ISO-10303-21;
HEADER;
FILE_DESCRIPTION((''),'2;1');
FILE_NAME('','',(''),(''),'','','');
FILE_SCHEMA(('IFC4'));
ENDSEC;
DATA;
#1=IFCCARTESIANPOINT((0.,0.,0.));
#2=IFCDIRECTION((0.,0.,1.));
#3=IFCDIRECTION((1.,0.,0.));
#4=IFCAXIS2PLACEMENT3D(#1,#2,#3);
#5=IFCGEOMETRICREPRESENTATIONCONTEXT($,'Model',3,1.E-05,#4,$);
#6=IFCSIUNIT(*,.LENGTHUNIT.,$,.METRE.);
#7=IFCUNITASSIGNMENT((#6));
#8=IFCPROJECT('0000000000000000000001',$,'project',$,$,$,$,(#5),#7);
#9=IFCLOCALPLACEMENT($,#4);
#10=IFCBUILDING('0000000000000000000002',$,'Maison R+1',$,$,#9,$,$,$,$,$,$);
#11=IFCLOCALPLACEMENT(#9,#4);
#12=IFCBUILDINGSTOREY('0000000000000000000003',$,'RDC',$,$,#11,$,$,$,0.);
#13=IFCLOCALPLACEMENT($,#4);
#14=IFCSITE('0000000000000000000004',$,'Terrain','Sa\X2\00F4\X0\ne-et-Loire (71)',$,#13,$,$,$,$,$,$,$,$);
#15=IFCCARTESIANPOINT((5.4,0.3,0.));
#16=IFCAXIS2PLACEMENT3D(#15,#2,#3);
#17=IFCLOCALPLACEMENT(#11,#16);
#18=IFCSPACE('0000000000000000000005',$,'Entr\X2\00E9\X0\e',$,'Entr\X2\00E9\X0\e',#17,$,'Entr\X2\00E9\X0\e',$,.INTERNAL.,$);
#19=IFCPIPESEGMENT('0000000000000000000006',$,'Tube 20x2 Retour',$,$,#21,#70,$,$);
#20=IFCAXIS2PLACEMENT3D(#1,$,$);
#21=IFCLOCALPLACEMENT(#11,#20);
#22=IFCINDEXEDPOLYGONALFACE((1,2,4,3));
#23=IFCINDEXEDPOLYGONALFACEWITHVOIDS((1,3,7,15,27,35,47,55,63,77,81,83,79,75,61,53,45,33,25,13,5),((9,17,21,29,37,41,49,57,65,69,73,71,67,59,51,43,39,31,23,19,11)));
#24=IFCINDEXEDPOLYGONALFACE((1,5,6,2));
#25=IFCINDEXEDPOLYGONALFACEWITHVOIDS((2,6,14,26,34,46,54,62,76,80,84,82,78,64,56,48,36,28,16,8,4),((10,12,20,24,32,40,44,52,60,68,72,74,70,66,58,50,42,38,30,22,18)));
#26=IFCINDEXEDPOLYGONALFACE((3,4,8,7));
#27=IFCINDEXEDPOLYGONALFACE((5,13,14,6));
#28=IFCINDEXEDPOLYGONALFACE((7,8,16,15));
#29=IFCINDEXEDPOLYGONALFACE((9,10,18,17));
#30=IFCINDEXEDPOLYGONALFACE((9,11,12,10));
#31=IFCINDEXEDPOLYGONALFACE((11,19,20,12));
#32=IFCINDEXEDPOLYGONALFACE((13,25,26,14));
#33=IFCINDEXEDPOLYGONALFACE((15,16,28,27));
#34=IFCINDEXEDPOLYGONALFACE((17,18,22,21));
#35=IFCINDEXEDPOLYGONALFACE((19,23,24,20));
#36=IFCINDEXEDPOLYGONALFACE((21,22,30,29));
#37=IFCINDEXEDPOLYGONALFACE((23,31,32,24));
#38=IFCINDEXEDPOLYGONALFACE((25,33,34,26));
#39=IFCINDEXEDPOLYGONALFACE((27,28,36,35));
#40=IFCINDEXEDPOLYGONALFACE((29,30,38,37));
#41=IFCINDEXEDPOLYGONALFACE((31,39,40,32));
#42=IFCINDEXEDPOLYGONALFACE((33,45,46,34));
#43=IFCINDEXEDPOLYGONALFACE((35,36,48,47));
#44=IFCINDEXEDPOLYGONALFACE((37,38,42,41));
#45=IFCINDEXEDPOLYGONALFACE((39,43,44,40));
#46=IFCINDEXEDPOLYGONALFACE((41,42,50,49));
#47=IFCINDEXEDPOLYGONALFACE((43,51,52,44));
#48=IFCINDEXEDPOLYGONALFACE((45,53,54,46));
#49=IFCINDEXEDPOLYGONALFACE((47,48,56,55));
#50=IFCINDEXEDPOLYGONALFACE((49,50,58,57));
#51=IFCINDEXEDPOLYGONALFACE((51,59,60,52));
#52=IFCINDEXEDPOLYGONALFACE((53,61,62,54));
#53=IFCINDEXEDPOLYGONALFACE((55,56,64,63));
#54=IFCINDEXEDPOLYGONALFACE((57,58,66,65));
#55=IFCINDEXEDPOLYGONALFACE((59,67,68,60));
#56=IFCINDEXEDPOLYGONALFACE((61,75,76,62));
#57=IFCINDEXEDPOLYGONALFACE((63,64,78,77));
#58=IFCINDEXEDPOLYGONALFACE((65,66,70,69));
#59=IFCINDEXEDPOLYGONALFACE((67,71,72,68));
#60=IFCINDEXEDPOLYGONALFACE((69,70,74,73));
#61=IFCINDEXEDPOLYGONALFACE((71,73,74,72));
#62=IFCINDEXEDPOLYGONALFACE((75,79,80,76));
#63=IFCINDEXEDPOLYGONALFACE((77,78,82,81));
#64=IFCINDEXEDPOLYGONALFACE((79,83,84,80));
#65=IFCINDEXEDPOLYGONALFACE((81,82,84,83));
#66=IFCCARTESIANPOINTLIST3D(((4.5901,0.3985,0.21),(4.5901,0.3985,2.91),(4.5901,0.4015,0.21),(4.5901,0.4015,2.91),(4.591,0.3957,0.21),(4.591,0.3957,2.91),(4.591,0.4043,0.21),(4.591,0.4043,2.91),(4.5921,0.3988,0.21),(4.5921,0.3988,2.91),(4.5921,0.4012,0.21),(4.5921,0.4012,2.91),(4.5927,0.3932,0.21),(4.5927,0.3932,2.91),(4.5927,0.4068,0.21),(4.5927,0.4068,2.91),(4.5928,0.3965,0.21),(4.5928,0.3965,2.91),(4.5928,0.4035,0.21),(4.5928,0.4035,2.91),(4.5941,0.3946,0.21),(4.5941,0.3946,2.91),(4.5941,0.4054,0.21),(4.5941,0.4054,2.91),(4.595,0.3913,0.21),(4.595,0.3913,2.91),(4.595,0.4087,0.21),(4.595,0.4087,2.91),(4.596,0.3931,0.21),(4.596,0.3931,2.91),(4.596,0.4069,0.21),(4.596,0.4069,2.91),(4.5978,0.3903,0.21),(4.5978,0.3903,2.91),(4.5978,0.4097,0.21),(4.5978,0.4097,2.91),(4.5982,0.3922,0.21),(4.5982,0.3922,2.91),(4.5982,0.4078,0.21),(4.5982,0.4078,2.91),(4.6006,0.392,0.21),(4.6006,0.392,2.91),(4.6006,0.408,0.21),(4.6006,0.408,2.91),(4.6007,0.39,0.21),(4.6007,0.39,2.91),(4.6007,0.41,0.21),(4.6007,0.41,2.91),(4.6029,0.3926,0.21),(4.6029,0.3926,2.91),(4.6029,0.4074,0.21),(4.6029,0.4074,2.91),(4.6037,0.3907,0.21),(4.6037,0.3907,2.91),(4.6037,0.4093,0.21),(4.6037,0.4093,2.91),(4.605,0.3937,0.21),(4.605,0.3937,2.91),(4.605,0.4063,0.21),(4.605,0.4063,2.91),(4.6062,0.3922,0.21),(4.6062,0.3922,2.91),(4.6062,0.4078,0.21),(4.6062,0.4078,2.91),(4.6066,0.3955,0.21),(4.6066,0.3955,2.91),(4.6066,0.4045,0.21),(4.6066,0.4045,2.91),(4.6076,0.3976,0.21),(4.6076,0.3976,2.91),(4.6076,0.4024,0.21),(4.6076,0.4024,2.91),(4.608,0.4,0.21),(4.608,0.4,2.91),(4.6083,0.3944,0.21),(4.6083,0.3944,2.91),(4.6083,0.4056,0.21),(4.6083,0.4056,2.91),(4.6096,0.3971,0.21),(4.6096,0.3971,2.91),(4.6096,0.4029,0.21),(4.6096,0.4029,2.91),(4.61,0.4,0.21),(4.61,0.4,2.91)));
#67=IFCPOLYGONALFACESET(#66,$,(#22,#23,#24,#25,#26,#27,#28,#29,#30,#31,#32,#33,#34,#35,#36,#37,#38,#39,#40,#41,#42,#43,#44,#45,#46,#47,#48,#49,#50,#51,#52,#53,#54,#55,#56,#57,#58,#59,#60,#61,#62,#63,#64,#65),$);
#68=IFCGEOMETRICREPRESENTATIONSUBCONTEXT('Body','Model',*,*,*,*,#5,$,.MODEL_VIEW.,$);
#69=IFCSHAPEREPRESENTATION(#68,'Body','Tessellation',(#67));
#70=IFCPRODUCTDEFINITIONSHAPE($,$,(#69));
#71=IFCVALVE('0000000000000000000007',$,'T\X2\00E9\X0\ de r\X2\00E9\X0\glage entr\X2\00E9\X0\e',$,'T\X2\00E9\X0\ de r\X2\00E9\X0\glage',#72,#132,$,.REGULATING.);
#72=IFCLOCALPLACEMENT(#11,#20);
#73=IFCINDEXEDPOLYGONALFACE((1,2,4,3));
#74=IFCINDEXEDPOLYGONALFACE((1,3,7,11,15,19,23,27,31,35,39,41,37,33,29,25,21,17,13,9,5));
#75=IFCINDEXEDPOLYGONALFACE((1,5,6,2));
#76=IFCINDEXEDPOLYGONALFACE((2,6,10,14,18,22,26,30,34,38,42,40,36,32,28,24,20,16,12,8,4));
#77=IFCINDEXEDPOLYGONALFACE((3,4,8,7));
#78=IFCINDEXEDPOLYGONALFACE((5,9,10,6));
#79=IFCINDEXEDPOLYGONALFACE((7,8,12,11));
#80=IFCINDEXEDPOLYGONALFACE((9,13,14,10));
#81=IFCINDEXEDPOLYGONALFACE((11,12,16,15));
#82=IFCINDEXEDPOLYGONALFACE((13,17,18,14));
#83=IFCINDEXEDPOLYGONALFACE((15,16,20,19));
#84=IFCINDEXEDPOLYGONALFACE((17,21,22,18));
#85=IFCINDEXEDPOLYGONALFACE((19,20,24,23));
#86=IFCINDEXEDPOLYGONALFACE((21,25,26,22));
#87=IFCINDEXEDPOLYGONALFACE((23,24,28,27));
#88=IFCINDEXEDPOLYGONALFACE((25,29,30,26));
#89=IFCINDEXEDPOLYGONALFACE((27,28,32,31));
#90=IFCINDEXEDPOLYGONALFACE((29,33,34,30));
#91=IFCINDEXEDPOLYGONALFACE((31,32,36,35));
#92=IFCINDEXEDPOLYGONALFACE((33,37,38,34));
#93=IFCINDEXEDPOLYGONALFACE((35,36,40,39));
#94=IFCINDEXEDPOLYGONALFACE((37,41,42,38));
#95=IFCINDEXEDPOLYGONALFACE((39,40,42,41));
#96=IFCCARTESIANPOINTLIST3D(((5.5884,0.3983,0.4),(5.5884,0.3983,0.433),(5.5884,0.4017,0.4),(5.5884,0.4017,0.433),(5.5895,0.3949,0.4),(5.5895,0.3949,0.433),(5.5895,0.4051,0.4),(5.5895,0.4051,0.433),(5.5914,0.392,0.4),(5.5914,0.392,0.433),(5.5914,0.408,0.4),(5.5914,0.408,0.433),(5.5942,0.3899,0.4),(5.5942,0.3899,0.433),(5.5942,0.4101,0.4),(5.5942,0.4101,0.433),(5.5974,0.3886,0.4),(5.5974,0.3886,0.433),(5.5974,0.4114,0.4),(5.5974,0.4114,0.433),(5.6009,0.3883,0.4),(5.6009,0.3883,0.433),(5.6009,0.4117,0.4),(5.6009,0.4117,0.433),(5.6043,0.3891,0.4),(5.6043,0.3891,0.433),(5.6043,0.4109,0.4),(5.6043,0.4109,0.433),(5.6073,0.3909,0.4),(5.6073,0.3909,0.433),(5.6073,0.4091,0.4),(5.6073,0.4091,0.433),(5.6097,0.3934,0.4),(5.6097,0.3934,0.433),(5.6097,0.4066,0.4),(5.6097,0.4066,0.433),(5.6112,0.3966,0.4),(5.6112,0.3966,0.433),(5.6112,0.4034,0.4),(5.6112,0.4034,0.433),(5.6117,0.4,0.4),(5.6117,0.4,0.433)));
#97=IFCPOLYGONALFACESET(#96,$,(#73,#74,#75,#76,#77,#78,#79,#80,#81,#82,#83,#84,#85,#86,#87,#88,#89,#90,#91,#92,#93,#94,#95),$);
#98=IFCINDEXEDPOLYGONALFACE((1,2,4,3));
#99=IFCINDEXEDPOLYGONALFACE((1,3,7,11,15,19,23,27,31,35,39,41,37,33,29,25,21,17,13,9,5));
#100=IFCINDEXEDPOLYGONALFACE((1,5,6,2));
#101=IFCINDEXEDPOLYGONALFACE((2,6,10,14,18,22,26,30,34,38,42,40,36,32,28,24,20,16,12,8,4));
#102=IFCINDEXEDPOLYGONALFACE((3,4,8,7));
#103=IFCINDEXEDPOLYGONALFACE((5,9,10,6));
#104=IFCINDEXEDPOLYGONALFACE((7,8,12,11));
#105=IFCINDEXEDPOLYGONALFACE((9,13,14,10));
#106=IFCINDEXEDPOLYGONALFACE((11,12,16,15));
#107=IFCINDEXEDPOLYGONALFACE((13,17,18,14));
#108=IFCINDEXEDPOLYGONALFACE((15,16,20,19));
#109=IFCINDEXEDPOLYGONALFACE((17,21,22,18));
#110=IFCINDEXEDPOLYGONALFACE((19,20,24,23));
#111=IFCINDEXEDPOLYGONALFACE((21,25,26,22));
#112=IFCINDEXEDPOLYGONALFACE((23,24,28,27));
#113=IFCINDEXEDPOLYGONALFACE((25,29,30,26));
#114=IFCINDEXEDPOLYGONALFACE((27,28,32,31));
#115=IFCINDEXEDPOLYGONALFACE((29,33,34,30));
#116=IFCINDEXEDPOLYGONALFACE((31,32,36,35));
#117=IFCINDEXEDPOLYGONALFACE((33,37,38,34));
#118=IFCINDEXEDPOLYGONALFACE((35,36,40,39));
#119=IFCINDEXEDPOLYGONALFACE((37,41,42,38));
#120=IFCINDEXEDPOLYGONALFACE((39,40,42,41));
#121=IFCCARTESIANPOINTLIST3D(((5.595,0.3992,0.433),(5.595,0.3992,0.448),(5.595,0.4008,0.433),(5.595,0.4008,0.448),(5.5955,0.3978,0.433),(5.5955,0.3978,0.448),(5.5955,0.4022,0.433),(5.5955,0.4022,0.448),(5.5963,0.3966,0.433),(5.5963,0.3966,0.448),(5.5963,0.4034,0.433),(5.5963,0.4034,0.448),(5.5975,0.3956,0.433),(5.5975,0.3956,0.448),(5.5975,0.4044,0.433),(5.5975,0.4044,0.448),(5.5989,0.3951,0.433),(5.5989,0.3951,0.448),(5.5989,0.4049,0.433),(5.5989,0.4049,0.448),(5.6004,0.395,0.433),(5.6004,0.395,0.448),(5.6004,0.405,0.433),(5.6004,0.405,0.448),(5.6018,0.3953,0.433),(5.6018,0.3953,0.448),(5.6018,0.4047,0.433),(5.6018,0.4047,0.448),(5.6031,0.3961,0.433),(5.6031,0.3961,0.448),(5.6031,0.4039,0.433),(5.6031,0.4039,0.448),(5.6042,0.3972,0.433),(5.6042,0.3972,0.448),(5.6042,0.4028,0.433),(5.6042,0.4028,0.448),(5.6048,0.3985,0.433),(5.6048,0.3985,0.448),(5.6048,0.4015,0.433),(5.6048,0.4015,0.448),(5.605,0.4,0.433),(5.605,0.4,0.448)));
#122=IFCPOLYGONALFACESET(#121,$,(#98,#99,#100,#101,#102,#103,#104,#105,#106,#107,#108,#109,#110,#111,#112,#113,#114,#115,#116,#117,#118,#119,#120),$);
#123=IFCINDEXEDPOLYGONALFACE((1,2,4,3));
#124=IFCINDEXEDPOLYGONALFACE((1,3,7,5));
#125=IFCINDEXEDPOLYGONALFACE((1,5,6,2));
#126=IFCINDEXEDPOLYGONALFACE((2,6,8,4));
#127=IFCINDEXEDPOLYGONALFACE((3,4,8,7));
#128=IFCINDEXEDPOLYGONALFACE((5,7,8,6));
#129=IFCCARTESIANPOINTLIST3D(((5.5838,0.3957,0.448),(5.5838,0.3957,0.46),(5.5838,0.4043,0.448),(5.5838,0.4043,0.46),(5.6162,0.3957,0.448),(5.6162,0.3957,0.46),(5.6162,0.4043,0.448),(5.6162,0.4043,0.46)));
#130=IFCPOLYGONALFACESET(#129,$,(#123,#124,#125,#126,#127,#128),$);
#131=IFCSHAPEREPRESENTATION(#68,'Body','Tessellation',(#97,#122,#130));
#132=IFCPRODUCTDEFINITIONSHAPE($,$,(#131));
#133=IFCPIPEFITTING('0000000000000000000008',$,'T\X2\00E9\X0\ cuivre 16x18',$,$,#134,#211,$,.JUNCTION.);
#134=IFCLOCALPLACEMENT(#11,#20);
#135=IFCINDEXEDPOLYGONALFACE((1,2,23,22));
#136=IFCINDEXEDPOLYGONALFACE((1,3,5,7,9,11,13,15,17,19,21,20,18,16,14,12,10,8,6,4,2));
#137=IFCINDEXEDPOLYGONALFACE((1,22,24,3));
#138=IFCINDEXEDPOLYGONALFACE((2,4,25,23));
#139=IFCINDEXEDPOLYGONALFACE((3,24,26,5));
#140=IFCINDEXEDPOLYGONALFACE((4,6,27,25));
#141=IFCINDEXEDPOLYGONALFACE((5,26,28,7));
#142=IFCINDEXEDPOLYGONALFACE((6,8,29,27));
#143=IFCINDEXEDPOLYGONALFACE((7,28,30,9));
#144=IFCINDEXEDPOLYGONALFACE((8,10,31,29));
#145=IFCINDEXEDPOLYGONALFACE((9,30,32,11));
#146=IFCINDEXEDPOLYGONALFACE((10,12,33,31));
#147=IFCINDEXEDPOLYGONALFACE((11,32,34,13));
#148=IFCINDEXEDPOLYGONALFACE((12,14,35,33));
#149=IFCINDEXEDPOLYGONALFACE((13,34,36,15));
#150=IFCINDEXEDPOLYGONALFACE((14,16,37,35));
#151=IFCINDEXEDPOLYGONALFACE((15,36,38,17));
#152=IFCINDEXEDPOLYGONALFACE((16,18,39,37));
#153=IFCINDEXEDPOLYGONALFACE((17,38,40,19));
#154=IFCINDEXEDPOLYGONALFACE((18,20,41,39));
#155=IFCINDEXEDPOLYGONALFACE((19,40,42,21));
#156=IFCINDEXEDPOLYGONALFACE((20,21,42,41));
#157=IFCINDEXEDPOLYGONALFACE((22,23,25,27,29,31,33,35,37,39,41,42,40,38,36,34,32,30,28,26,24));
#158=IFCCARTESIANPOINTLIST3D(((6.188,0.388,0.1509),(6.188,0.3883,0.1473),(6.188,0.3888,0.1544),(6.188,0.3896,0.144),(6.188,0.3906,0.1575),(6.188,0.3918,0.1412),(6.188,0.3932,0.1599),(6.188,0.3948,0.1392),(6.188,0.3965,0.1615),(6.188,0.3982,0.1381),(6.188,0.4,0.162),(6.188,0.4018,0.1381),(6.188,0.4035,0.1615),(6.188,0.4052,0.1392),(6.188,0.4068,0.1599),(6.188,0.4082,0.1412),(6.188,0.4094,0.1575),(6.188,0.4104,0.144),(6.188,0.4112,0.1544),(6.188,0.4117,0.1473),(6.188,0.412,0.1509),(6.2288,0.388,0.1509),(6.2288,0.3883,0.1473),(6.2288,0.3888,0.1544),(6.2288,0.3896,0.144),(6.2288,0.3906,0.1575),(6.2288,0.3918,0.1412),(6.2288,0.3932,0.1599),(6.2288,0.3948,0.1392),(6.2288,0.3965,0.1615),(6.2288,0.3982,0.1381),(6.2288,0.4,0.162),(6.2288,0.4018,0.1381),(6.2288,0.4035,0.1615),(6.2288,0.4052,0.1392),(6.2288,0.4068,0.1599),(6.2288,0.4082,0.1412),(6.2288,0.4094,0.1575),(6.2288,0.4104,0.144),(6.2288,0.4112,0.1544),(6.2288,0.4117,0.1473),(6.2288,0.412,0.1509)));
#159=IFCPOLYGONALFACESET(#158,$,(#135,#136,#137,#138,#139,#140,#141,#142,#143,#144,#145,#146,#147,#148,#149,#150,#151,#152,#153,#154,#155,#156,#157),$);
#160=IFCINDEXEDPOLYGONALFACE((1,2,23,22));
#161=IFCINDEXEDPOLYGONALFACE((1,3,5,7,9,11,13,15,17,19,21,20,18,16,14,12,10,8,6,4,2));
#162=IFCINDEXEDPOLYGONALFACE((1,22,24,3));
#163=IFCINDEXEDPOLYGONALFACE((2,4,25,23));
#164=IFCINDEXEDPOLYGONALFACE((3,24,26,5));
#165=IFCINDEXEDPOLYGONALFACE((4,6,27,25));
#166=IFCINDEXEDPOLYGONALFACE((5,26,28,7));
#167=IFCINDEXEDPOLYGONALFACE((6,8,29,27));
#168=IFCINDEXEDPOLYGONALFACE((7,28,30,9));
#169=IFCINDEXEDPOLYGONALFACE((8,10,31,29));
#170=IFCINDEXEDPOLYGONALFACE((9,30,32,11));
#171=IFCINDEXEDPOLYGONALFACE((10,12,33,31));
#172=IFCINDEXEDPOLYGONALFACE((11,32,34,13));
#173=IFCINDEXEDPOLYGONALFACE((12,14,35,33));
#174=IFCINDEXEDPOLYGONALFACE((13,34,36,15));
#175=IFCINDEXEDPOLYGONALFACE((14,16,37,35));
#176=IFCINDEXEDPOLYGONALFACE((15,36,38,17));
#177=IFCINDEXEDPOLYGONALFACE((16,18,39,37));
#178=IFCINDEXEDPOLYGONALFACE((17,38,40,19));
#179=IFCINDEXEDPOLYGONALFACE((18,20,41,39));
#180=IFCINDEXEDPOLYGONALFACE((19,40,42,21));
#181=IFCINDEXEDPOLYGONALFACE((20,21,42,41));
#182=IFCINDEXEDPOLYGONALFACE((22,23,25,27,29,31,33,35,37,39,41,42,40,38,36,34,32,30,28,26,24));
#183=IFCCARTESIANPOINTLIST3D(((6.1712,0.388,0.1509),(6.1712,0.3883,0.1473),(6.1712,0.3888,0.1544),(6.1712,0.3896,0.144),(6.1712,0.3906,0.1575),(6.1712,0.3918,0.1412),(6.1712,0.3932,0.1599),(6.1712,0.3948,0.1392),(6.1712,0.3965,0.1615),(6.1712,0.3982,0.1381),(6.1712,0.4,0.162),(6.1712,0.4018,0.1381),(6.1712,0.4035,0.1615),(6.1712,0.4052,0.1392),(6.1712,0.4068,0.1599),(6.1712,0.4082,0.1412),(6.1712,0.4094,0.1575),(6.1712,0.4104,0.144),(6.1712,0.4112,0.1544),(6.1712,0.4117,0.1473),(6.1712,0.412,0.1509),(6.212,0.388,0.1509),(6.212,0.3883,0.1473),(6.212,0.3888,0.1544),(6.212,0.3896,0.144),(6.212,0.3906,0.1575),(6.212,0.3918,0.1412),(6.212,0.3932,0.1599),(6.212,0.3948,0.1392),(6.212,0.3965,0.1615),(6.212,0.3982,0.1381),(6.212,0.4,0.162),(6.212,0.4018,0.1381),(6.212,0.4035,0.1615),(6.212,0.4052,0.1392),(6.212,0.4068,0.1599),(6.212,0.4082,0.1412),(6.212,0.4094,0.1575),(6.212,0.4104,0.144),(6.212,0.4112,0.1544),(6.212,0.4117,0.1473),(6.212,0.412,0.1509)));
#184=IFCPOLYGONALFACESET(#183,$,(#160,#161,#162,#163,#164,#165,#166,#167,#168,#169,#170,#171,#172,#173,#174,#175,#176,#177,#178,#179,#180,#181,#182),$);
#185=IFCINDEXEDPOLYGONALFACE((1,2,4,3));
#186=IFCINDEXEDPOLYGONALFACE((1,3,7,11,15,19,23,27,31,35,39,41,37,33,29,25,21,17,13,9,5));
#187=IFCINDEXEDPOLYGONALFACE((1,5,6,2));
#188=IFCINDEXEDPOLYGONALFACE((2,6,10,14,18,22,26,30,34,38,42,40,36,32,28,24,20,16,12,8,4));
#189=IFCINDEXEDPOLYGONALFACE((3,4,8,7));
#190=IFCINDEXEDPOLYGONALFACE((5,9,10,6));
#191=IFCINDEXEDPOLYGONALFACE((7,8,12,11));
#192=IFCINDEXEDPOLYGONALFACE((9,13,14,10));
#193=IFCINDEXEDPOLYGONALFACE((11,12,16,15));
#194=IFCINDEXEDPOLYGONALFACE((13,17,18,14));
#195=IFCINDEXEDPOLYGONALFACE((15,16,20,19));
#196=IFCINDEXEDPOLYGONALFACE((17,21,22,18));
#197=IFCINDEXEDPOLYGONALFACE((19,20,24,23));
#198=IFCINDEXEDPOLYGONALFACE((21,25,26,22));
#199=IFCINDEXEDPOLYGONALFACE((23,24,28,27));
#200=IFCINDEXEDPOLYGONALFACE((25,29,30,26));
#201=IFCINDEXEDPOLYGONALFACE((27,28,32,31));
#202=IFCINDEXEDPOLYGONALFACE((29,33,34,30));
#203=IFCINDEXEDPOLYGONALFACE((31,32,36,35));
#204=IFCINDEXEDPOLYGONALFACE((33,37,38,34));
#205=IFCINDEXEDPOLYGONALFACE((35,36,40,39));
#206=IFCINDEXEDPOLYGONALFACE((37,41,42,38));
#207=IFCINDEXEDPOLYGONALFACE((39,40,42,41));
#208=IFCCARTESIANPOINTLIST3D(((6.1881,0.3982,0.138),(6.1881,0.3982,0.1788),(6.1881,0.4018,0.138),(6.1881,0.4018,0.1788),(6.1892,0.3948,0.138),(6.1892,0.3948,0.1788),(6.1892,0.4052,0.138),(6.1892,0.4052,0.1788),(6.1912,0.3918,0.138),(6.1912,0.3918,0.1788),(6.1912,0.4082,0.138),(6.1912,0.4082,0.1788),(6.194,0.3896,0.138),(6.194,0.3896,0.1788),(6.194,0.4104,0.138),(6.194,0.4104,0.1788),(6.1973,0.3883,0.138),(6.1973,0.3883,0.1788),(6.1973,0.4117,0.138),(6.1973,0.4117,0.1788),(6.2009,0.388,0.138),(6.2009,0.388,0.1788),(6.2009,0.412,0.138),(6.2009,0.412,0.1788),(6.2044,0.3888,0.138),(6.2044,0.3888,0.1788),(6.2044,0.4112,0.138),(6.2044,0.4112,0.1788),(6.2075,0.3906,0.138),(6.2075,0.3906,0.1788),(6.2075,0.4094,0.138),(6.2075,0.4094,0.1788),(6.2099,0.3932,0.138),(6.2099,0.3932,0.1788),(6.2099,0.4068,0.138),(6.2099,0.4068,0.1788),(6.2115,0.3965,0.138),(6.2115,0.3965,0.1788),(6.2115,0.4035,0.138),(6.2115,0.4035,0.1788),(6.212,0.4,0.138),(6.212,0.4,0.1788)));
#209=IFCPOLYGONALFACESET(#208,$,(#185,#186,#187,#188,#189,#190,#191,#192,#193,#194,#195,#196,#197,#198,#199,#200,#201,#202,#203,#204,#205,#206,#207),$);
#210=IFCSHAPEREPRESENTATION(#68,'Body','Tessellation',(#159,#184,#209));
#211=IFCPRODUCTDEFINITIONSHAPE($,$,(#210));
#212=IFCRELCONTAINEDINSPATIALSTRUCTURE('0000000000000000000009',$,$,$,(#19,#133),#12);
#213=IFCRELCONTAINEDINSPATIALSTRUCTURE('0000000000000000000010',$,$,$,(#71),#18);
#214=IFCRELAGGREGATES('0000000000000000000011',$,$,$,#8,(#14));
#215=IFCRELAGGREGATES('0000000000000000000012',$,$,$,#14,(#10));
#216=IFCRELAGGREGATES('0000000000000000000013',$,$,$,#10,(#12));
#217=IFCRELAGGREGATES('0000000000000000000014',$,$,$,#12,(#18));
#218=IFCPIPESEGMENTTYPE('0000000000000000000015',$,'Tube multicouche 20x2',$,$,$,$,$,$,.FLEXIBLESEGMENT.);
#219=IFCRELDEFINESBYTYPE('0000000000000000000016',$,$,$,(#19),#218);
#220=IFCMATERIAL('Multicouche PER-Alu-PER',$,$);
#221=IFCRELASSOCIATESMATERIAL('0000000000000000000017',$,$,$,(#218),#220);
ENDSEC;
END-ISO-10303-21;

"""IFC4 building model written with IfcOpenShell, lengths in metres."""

from ifc_helpers import new_model, si_unit, frame, frame_2d, origin_with_axes, place, context, subcontext, project, spatial, rectangle, circle, hollow_circle, extrude, material, type_object, element, save


model = new_model("IFC4")

# Units and contexts
model_context = context("Model", 3, precision=1e-05, world=origin_with_axes())
body_context = subcontext(model_context, "Body", "Model", "MODEL_VIEW")
ifc_project = project(units=[si_unit("LENGTHUNIT", "METRE")], contexts=[model_context])

# Site, building, storey
site_placement = place(None, origin_with_axes())
site = spatial("IfcSite", under=ifc_project, at=site_placement, Name="Terrain", Description="Saône-et-Loire (71)")
building_placement = place(None, origin_with_axes())
building = spatial("IfcBuilding", under=site, at=building_placement, Name="Maison R+1")
storey_placement = place(building_placement, origin_with_axes())
storey = spatial("IfcBuildingStorey", under=building, at=storey_placement, Name="RDC", Elevation=0.0)

# Pipe segment
ifc_material_1 = material(Name="Multicouche PER-Alu-PER")
pipe_segment_type_1 = type_object("IfcPipeSegmentType", Name="Tube multicouche 20x2", PredefinedType="FLEXIBLESEGMENT", material=ifc_material_1)
for number, where, z_axis, x_axis, name in (
    (1, (4.6, 0.4, 0.21), (0.0, 0.0, 1.0), (1.0, 0.0, 0.0), "Tube 20x2 Retour"),
):
    element("IfcPipeSegment", number, at=place(storey_placement, frame(where, z_axis=z_axis, x_axis=x_axis)), inside=storey, type_object=pipe_segment_type_1, Name=name, context=body_context, shape_type="SweptSolid", body=[
        extrude(hollow_circle(Radius=0.01, WallThickness=0.002), origin_with_axes(), (0.0, 0.0, 1.0), 2.7),
    ])

# Shared definitions
space_placement = place(storey_placement, frame((5.4, 0.3, 0.0), z_axis=(0.0, 0.0, 1.0), x_axis=(1.0, 0.0, 0.0)))
space = spatial("IfcSpace", under=storey, at=space_placement, Name="Entrée", ObjectType="Entrée", LongName="Entrée", PredefinedType="INTERNAL")

# Valve
valve_1_placement = place(space_placement, frame((0.2, 0.1, 0.4), z_axis=(0.0, 0.0, 1.0), x_axis=(1.0, 0.0, 0.0)))
element("IfcValve", 2, at=valve_1_placement, inside=space, Name="Té de réglage entrée", ObjectType="Té de réglage", PredefinedType="REGULATING", context=body_context, shape_type="SweptSolid", body=[
    extrude(circle(Radius=0.0117), origin_with_axes(), (0.0, 0.0, 1.0), 0.033),
    extrude(circle(Radius=0.005), frame((0.0, 0.0, 0.033), z_axis=(0.0, 0.0, 1.0), x_axis=(1.0, 0.0, 0.0)), (0.0, 0.0, 1.0), 0.015),
    extrude(rectangle(XDim=0.0324, YDim=0.0086, at=frame_2d((0.0162, 0.0043))), frame((-0.0162, -0.0043, 0.048), z_axis=(0.0, 0.0, 1.0), x_axis=(1.0, 0.0, 0.0)), (0.0, 0.0, 1.0), 0.012),
])

# Pipe fitting
for number, where, z_axis, x_axis, name in (
    (3, (6.2, 0.4, 0.15), (0.0, 0.0, 1.0), (1.0, 0.0, 0.0), "Té cuivre 16x18"),
):
    element("IfcPipeFitting", number, at=place(storey_placement, frame(where, z_axis=z_axis, x_axis=x_axis)), inside=storey, Name=name, PredefinedType="JUNCTION", context=body_context, shape_type="SweptSolid", body=[
        extrude(circle(Radius=0.012), frame((-0.012, 0.0, 0.0), z_axis=(1.0, 0.0, 0.0), x_axis=(0.0, 0.0, 1.0)), (0.0, 0.0, 1.0), 0.0408),
        extrude(circle(Radius=0.012), frame((0.012, 0.0, 0.0), z_axis=(-1.0, 0.0, 0.0), x_axis=(0.0, 0.0, 1.0)), (0.0, 0.0, 1.0), 0.0408),
        extrude(circle(Radius=0.012), frame((0.0, 0.0, -0.012), z_axis=(0.0, 0.0, 1.0), x_axis=(1.0, 0.0, 0.0)), (0.0, 0.0, 1.0), 0.0408),
    ])

save(model, "model.ifc")
